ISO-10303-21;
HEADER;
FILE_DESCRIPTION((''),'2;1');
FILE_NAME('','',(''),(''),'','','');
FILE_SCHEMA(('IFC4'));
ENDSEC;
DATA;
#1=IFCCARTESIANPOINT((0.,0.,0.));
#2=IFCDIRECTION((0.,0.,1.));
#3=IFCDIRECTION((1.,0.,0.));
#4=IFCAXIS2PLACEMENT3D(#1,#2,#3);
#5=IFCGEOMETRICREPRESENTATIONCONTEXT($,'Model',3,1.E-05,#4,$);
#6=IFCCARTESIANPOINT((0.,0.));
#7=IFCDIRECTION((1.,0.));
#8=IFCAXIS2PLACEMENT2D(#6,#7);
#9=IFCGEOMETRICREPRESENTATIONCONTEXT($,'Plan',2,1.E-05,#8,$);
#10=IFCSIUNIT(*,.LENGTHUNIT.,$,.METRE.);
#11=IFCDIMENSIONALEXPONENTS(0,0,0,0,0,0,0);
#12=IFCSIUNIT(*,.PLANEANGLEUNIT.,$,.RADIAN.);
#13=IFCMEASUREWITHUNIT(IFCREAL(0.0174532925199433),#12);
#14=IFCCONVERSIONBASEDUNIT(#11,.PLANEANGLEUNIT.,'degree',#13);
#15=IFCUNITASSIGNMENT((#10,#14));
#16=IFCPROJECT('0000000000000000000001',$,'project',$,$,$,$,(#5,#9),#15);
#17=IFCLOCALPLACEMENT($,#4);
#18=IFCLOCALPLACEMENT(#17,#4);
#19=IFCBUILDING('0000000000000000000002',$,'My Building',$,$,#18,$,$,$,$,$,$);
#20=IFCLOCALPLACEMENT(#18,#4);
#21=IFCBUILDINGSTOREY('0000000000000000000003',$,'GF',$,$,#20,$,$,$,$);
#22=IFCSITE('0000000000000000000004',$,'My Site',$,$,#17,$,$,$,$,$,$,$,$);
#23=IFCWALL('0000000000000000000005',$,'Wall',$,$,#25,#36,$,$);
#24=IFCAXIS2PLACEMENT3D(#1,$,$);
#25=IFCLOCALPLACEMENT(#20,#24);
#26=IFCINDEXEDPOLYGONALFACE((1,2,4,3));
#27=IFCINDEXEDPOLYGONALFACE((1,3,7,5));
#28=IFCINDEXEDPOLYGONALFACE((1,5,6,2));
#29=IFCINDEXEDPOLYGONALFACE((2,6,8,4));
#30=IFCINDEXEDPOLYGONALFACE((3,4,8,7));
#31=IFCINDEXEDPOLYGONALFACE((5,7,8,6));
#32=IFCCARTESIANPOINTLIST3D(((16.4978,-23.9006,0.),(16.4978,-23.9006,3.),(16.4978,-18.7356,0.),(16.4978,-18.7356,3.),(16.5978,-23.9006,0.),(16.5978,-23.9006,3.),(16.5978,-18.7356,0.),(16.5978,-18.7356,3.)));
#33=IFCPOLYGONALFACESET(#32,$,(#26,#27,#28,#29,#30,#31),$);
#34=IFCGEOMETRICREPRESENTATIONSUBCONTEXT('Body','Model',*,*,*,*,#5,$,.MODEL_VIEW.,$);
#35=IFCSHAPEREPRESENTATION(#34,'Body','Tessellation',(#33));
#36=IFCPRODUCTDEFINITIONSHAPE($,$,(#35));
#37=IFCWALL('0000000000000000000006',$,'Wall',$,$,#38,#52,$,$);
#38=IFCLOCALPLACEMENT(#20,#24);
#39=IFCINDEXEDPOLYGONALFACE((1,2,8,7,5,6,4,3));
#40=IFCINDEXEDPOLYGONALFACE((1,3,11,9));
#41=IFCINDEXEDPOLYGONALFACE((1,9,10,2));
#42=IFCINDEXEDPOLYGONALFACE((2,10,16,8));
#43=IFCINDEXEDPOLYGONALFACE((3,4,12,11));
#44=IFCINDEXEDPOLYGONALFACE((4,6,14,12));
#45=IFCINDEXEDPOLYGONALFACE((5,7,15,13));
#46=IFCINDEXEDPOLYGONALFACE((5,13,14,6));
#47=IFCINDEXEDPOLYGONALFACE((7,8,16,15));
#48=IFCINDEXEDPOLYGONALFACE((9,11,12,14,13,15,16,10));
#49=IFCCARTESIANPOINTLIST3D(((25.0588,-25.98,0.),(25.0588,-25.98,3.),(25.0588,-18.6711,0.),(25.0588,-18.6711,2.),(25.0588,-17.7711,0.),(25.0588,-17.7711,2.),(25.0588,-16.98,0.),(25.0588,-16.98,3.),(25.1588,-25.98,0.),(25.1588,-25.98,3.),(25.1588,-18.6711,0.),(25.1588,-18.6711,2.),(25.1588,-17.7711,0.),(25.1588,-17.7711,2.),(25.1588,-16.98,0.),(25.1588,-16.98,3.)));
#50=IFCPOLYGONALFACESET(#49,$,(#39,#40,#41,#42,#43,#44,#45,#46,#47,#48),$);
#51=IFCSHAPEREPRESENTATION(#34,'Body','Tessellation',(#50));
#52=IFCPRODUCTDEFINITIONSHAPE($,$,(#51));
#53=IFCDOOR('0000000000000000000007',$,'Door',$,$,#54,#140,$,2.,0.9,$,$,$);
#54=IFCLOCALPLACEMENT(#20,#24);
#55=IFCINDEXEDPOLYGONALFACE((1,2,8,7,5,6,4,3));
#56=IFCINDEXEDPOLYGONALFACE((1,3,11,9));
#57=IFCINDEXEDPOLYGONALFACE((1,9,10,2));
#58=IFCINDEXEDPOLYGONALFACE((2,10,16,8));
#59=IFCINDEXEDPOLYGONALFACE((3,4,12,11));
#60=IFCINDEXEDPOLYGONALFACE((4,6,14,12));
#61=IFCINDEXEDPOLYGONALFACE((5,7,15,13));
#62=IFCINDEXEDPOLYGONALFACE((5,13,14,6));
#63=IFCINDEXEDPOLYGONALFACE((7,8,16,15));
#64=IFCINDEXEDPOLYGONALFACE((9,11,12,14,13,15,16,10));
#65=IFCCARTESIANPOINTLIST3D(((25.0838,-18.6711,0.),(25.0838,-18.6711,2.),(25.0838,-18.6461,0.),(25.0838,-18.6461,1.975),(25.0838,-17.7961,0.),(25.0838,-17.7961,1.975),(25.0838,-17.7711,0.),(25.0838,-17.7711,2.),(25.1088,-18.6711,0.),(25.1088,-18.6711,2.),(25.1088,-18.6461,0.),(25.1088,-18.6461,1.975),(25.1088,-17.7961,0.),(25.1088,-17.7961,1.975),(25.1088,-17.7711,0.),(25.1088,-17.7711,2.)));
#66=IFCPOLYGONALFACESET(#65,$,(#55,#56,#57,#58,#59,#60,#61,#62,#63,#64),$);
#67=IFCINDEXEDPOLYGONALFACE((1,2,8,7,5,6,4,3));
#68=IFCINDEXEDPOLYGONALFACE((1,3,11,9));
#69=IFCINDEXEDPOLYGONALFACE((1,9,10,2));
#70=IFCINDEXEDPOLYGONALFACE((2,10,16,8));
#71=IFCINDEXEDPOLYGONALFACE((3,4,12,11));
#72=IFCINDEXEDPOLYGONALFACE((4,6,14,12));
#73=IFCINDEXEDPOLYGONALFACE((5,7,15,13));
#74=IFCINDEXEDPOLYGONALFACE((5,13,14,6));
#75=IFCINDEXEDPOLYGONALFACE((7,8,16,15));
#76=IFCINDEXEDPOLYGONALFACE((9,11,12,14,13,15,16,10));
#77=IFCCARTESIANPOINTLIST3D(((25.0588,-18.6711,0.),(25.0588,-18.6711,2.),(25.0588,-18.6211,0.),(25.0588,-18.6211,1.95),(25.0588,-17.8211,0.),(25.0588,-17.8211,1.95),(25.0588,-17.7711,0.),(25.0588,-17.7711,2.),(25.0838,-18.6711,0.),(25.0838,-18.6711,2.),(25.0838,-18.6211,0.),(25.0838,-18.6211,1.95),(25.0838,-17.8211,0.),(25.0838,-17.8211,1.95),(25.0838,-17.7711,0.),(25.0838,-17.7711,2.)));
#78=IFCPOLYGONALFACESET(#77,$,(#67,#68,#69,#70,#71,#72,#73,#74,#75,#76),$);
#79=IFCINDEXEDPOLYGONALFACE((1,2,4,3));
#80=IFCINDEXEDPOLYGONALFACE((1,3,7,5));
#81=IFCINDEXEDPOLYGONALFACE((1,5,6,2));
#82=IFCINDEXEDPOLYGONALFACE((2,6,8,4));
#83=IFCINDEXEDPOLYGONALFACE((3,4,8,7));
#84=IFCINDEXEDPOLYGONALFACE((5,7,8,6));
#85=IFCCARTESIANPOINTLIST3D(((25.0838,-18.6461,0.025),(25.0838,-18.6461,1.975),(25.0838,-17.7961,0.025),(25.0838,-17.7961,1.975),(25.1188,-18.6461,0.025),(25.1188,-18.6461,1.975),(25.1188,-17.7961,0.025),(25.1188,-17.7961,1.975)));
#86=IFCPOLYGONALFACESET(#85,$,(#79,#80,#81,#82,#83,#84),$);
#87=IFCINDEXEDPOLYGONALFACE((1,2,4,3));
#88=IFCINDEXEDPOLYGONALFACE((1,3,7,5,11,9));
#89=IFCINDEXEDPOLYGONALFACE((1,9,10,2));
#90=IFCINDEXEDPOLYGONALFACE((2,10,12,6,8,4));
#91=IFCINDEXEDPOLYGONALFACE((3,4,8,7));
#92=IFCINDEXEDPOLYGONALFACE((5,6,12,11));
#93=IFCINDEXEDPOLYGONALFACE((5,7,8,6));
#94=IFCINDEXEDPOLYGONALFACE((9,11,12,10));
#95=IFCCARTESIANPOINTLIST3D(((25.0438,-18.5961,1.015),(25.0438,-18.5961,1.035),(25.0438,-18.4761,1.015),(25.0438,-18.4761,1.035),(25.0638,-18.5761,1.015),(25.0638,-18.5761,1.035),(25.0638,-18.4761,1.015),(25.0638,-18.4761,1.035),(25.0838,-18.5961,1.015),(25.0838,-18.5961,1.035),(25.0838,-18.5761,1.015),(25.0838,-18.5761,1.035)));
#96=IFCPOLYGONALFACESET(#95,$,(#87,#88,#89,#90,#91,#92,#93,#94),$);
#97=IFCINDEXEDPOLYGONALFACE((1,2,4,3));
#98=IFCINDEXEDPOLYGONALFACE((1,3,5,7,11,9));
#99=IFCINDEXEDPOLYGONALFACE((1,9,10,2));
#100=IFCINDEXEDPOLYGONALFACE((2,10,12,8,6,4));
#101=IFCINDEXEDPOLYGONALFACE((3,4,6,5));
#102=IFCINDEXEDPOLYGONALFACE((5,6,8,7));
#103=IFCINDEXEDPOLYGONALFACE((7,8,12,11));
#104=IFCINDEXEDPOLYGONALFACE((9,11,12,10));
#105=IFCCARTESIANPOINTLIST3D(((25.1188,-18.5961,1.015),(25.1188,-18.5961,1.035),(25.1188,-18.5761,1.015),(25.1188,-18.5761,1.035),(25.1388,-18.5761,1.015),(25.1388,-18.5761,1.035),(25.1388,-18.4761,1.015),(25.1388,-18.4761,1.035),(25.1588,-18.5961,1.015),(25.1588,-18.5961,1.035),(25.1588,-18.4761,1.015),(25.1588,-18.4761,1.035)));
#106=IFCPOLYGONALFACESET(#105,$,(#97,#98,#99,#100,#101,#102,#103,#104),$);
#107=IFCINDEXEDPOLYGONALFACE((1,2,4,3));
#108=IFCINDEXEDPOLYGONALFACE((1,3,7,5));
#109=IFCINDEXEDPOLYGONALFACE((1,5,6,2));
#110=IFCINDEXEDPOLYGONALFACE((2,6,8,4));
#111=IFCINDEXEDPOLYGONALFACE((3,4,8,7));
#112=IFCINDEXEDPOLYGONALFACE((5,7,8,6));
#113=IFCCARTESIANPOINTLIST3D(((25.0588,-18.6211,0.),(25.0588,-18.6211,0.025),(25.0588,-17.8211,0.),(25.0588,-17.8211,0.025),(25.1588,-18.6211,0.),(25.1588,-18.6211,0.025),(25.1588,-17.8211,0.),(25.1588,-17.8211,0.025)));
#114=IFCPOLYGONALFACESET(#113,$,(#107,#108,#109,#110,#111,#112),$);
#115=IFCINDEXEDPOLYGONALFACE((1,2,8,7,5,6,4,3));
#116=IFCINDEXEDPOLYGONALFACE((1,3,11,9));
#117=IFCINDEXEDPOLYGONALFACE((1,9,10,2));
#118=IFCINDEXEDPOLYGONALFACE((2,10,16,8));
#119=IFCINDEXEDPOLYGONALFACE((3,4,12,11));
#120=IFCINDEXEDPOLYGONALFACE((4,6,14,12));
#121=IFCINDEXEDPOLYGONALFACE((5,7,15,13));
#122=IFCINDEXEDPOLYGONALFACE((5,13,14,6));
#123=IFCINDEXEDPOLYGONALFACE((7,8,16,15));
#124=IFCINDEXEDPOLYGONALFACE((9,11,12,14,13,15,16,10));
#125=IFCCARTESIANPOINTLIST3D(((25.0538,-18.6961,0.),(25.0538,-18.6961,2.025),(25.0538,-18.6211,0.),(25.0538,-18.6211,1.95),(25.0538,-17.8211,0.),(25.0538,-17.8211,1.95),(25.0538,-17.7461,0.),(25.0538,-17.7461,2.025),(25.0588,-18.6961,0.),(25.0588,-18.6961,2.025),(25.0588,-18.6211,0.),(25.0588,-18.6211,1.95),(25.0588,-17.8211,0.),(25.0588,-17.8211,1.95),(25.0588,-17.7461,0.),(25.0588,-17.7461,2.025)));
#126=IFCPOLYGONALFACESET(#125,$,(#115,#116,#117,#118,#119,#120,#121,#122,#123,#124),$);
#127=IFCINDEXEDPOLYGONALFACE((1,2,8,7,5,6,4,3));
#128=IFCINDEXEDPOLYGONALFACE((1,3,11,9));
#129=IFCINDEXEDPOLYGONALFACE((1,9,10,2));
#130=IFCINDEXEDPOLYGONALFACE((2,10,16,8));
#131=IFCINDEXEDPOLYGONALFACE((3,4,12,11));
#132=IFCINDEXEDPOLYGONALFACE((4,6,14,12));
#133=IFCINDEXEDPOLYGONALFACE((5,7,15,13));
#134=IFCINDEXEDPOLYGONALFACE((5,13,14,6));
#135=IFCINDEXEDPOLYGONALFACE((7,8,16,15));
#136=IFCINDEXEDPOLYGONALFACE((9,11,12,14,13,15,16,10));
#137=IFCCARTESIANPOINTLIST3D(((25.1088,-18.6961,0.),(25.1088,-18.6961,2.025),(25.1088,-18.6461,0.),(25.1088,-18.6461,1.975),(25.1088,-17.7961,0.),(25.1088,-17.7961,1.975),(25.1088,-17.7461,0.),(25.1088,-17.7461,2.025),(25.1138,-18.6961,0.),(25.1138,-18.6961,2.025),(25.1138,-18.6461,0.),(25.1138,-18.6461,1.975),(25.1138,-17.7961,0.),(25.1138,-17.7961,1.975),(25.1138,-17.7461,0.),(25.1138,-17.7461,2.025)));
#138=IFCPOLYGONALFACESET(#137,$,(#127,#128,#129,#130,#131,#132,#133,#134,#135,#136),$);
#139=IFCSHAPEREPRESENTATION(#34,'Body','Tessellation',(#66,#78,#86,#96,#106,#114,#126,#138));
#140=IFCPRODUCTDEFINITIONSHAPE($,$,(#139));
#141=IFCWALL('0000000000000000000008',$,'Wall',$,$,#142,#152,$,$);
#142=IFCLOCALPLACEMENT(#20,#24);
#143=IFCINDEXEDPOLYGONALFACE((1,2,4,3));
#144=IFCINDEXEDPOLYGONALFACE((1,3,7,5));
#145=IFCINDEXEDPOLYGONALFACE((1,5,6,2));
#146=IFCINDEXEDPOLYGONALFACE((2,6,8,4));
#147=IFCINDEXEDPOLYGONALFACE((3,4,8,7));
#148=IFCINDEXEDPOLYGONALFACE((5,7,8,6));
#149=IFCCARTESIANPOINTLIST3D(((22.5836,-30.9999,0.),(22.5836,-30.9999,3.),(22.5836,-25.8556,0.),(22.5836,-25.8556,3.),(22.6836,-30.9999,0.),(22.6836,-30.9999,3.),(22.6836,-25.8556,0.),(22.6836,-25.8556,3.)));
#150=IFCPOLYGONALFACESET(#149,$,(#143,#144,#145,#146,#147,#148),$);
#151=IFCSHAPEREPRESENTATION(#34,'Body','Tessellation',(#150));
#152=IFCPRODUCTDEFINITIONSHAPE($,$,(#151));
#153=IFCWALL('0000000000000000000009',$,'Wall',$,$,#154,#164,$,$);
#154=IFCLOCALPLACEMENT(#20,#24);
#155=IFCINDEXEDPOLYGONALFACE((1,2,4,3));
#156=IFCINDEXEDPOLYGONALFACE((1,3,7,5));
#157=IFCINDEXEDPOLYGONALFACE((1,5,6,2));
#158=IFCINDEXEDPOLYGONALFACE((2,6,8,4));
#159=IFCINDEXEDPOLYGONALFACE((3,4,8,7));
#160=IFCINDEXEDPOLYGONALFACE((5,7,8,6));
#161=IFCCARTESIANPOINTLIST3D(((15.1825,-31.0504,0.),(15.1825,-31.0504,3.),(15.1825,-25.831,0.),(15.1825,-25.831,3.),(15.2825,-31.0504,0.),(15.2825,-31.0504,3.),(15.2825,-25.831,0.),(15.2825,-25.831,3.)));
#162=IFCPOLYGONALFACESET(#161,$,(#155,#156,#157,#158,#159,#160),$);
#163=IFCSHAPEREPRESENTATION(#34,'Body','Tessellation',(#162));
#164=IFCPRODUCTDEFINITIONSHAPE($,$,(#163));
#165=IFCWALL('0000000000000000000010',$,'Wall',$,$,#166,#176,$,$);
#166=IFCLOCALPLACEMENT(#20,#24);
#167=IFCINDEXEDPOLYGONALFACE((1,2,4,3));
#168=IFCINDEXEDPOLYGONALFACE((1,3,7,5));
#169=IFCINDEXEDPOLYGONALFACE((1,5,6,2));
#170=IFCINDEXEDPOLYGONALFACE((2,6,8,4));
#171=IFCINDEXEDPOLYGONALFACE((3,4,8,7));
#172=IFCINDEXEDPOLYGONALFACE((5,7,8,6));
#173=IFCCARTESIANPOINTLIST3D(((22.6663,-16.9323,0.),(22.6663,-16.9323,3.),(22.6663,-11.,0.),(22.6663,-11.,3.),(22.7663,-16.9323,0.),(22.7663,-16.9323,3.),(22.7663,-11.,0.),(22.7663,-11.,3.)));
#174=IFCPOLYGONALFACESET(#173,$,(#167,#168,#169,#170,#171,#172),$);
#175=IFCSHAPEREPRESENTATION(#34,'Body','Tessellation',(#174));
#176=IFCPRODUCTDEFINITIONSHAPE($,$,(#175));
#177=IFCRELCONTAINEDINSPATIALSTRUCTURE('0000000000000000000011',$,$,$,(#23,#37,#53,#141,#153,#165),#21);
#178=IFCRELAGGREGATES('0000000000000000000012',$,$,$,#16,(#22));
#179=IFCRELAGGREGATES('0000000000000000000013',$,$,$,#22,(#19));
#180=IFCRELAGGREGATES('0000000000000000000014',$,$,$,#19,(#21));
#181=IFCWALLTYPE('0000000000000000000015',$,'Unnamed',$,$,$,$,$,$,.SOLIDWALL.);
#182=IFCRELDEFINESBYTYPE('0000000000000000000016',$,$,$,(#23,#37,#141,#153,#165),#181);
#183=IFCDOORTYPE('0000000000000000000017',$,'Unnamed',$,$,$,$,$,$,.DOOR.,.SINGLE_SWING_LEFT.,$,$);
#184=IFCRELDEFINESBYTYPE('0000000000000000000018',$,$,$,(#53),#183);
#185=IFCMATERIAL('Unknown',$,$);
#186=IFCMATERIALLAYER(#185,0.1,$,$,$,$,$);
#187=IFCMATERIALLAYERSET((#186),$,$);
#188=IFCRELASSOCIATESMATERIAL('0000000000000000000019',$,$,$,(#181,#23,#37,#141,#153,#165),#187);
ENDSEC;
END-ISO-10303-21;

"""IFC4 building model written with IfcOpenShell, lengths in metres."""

from ifc_helpers import new_model, entity, si_unit, converted_unit, frame, origin_with_axes, origin_2d_with_axis, place, context, subcontext, project, spatial, line, indexed_curve, outline, extrude, shape, source, transform, mapped, material, layer, layer_set, layer_usage, type_object, type_shapes, element, fill, save


model = new_model("IFC4")

# Units and contexts
model_context = context("Model", 3, precision=1e-05, world=origin_with_axes())
plan_context = context("Plan", 2, precision=1e-05, world=origin_2d_with_axis())
body_context_1 = subcontext(model_context, "Body", "Model", "MODEL_VIEW")
body_context_2 = subcontext(plan_context, "Body", "Plan", "PLAN_VIEW")
ifc_project = project(units=[si_unit("LENGTHUNIT", "METRE"), converted_unit("PLANEANGLEUNIT", "degree", entity("IfcReal", 0.0174532925199433), si_unit("PLANEANGLEUNIT", "RADIAN"), dimensions=[0, 0, 0, 0, 0, 0, 0])], contexts=[model_context, plan_context])

# Site, building, storey
site_placement = place(None, origin_with_axes())
site = spatial("IfcSite", under=ifc_project, at=site_placement, Name="My Site")
building_placement = place(site_placement, origin_with_axes())
building = spatial("IfcBuilding", under=site, at=building_placement, Name="My Building")
storey_placement = place(building_placement, origin_with_axes())
storey = spatial("IfcBuildingStorey", under=building, at=storey_placement, Name="GF")

# Shared definitions
ifc_material = material(Name="Unknown")
ifc_layer = layer(ifc_material, 0.1)
ifc_layer_set = layer_set([ifc_layer])
wall_type = type_object("IfcWallType", Name="Unnamed", PredefinedType="SOLIDWALL", material=ifc_layer_set)

# Shared definitions
shared_shape_1 = source(origin_with_axes(), body_context_1, "Body", "SweptSolid", [
    extrude(outline(indexed_curve([(0.0, 0.0), (0.9, 0.0), (0.9, 2.0), (0.0, 2.0)], segments=[line(1, 2, 3, 4, 1)])), frame((0.0, -0.6, 0.0), z_axis=(0.0, -1.0, 0.0), x_axis=(1.0, 0.0, 0.0)), (0.0, 0.0, -1.0), 1.2),
])
door_type = type_object("IfcDoorType", Name="Unnamed", OperationType="SINGLE_SWING_LEFT", PredefinedType="DOOR")
shared_shape_2 = source(origin_with_axes(), body_context_1, "Body", "SweptSolid", [
    extrude(outline(indexed_curve([(0.0, 0.0), (0.0, 2.0), (0.9, 2.0), (0.9, 0.0), (0.875, 0.0), (0.875, 1.975), (0.025, 1.975), (0.025, 0.0)], segments=[line(1, 2, 3, 4, 5, 6, 7, 8, 1)])), frame((0.0, 0.025, 0.0), z_axis=(0.0, -1.0, 0.0), x_axis=(1.0, 0.0, 0.0)), (0.0, 0.0, -1.0), 0.025),
    extrude(outline(indexed_curve([(0.0, 0.0), (0.0, 2.0), (0.9, 2.0), (0.9, 0.0), (0.85, 0.0), (0.85, 1.95), (0.05, 1.95), (0.05, 0.0)], segments=[line(1, 2, 3, 4, 5, 6, 7, 8, 1)])), frame((0.0, 0.0, 0.0), z_axis=(0.0, -1.0, 0.0), x_axis=(1.0, 0.0, 0.0)), (0.0, 0.0, -1.0), 0.025),
    extrude(outline(indexed_curve([(0.0, 0.0), (0.85, 0.0), (0.85, 0.035), (0.0, 0.035)], segments=[line(1, 2, 3, 4, 1)])), frame((0.025, 0.025, 0.025), z_axis=(0.0, 0.0, 1.0), x_axis=(1.0, 0.0, 0.0)), (0.0, 0.0, 1.0), 1.95),
    extrude(outline(indexed_curve([(0.0, 0.0), (0.0, -0.04), (-0.12, -0.04), (-0.12, -0.02), (-0.02, -0.02), (-0.02, 0.0)], segments=[line(1, 2, 3, 4, 5, 6, 1)])), frame((0.825, 0.025, 1.015), z_axis=(0.0, 0.0, 1.0), x_axis=(1.0, 0.0, 0.0)), (0.0, 0.0, 1.0), 0.02),
    extrude(outline(indexed_curve([(0.0, 0.0), (0.0, 0.04), (-0.12, 0.04), (-0.12, 0.02), (-0.02, 0.02), (-0.02, 0.0)], segments=[line(1, 2, 3, 4, 5, 6, 1)])), frame((0.825, 0.06, 1.015), z_axis=(0.0, 0.0, 1.0), x_axis=(1.0, 0.0, 0.0)), (0.0, 0.0, 1.0), 0.02),
    extrude(outline(indexed_curve([(0.0, 0.0), (0.8, 0.0), (0.8, 0.1), (0.0, 0.1)], segments=[line(1, 2, 3, 4, 1)])), frame((0.05, 0.0, 0.0), z_axis=(0.0, 0.0, 1.0), x_axis=(1.0, 0.0, 0.0)), (0.0, 0.0, 1.0), 0.025),
    extrude(outline(indexed_curve([(0.0, 0.0), (0.0, 2.025), (0.95, 2.025), (0.95, 0.0), (0.875, 0.0), (0.875, 1.95), (0.075, 1.95), (0.075, 0.0)], segments=[line(1, 2, 3, 4, 5, 6, 7, 8, 1)])), frame((-0.025, -0.005, 0.0), z_axis=(0.0, -1.0, 0.0), x_axis=(1.0, 0.0, 0.0)), (0.0, 0.0, -1.0), 0.005),
    extrude(outline(indexed_curve([(0.0, 0.0), (0.0, 2.025), (0.95, 2.025), (0.95, 0.0), (0.9, 0.0), (0.9, 1.975), (0.05, 1.975), (0.05, 0.0)], segments=[line(1, 2, 3, 4, 5, 6, 7, 8, 1)])), frame((-0.025, 0.05, 0.0), z_axis=(0.0, -1.0, 0.0), x_axis=(1.0, 0.0, 0.0)), (0.0, 0.0, -1.0), 0.005),
])
shared_shape_3 = source(origin_with_axes(), body_context_2, "Body", "Curve2D", [
    entity("IfcIndexedPolyCurve", entity("IfcCartesianPointList2D", [[0.0, 0.0], [0.0, 0.05], [0.025, 0.05], [0.025, 0.025], [0.05, 0.025], [0.05, 0.0]]), [entity("IfcLineIndex", [1, 2, 3, 4, 5, 6, 1])]),
    entity("IfcIndexedPolyCurve", entity("IfcCartesianPointList2D", [[0.9, 0.0], [0.9, 0.05], [0.875, 0.05], [0.875, 0.025], [0.85, 0.025], [0.85, 0.0]]), [entity("IfcLineIndex", [1, 2, 3, 4, 5, 6, 1])]),
    entity("IfcTrimmedCurve", entity("IfcEllipse", entity("IfcAxis2Placement2D", entity("IfcCartesianPoint", [0.06, 0.05]), entity("IfcDirection", [1.0, 0.0])), 0.815, 0.85), [entity("IfcCartesianPoint", [0.875, 0.05])], [entity("IfcCartesianPoint", [0.06, 0.9])], True, "CARTESIAN"),
    entity("IfcIndexedPolyCurve", entity("IfcCartesianPointList2D", [[0.025, 0.05], [0.06, 0.05], [0.06, 0.9], [0.025, 0.9]]), [entity("IfcLineIndex", [1, 2, 3, 4, 1])]),
])
type_shapes(door_type, [shared_shape_2, shared_shape_3])

# Wall
ifc_layer_usage_1 = layer_usage(ifc_layer_set, "AXIS2", "POSITIVE", 0.0)
wall_1_placement = place(storey_placement, frame((16.4978, -18.7356, 0.0), z_axis=(0.0, 0.0, 1.0), x_axis=(0.0, -1.0, 0.0)))
element("IfcWall", 1, at=wall_1_placement, inside=storey, type_object=wall_type, material=ifc_layer_usage_1, Name="Wall", context=body_context_1, shape_type="SweptSolid", body=[
    extrude(outline(indexed_curve([(0.0, 0.0), (0.0, 0.1), (5.1651, 0.1), (5.1651, 0.0)], segments=[line(1, 2, 3, 4, 1)])), origin_with_axes(), (0.0, 0.0, 1.0), 3.0),
])

# Wall, opening, door
ifc_layer_usage_2 = layer_usage(ifc_layer_set, "AXIS2", "POSITIVE", 0.0)
wall_2_placement = place(storey_placement, frame((25.0588, -16.98, 0.0), z_axis=(0.0, 0.0, 1.0), x_axis=(0.0, -1.0, 0.0)))
wall_2 = element("IfcWall", 2, at=wall_2_placement, inside=storey, type_object=wall_type, material=ifc_layer_usage_2, Name="Wall", context=body_context_1, shape_type="SweptSolid", body=[
    extrude(outline(indexed_curve([(0.0, 0.0), (0.0, 0.1), (9.0, 0.1), (9.0, 0.0)], segments=[line(1, 2, 3, 4, 1)])), origin_with_axes(), (0.0, 0.0, 1.0), 3.0),
])
opening_1_placement = place(wall_2_placement, frame((0.7911, 0.0, 0.0), z_axis=(0.0, 0.0, 1.0), x_axis=(1.0, 0.0, 0.0)))
opening_1 = element("IfcOpeningElement", 3, at=opening_1_placement, cuts=wall_2, PredefinedType="OPENING", context=body_context_1, shape_type="MappedRepresentation", body=[
    mapped(shared_shape_1, transform((0.0, 0.0, 0.0), x_axis=(1.0, 0.0, 0.0), y_axis=(0.0, 1.0, 0.0), z_axis=(0.0, 0.0, 1.0), scale=1.0)),
])
door_1_placement = place(opening_1_placement, frame((0.0, 0.0, 0.0), z_axis=(0.0, 0.0, 1.0), x_axis=(1.0, 0.0, 0.0)))
door_1 = element("IfcDoor", 4, at=door_1_placement, inside=storey, type_object=door_type, Name="Door", OverallHeight=2.0, OverallWidth=0.9, shapes=[
    shape(body_context_1, "Body", "MappedRepresentation", [mapped(shared_shape_2, transform((0.0, 0.0, 0.0), x_axis=(1.0, 0.0, 0.0), y_axis=(0.0, 1.0, 0.0), z_axis=(0.0, 0.0, 1.0), scale=1.0))]),
    shape(body_context_2, "Body", "MappedRepresentation", [mapped(shared_shape_3, transform((0.0, 0.0, 0.0), x_axis=(1.0, 0.0, 0.0), y_axis=(0.0, 1.0, 0.0), z_axis=(0.0, 0.0, 1.0), scale=1.0))]),
])
fill(opening_1, door_1)

# Walls
ifc_layer_usage_3 = layer_usage(ifc_layer_set, "AXIS2", "POSITIVE", 0.0)
wall_3_placement = place(storey_placement, frame((22.5836, -25.8556, 0.0), z_axis=(0.0, 0.0, 1.0), x_axis=(0.0, -1.0, 0.0)))
element("IfcWall", 5, at=wall_3_placement, inside=storey, type_object=wall_type, material=ifc_layer_usage_3, Name="Wall", context=body_context_1, shape_type="SweptSolid", body=[
    extrude(outline(indexed_curve([(0.0, 0.0), (0.0, 0.1), (5.1443, 0.1), (5.1443, 0.0)], segments=[line(1, 2, 3, 4, 1)])), origin_with_axes(), (0.0, 0.0, 1.0), 3.0),
])
ifc_layer_usage_4 = layer_usage(ifc_layer_set, "AXIS2", "POSITIVE", 0.0)
wall_4_placement = place(storey_placement, frame((15.1825, -25.831, 0.0), z_axis=(0.0, 0.0, 1.0), x_axis=(0.0, -1.0, 0.0)))
element("IfcWall", 6, at=wall_4_placement, inside=storey, type_object=wall_type, material=ifc_layer_usage_4, Name="Wall", context=body_context_1, shape_type="SweptSolid", body=[
    extrude(outline(indexed_curve([(0.0, 0.0), (0.0, 0.1), (5.2194, 0.1), (5.2194, 0.0)], segments=[line(1, 2, 3, 4, 1)])), origin_with_axes(), (0.0, 0.0, 1.0), 3.0),
])
ifc_layer_usage_5 = layer_usage(ifc_layer_set, "AXIS2", "POSITIVE", 0.0)
wall_5_placement = place(storey_placement, frame((22.7663, -16.9323, 0.0), z_axis=(0.0, 0.0, 1.0), x_axis=(0.0, 1.0, 0.0)))
element("IfcWall", 7, at=wall_5_placement, inside=storey, type_object=wall_type, material=ifc_layer_usage_5, Name="Wall", context=body_context_1, shape_type="SweptSolid", body=[
    extrude(outline(indexed_curve([(0.0, 0.0), (0.0, 0.1), (5.9323, 0.1), (5.9323, 0.0)], segments=[line(1, 2, 3, 4, 1)])), origin_with_axes(), (0.0, 0.0, 1.0), 3.0),
])

save(model, "model.ifc")
